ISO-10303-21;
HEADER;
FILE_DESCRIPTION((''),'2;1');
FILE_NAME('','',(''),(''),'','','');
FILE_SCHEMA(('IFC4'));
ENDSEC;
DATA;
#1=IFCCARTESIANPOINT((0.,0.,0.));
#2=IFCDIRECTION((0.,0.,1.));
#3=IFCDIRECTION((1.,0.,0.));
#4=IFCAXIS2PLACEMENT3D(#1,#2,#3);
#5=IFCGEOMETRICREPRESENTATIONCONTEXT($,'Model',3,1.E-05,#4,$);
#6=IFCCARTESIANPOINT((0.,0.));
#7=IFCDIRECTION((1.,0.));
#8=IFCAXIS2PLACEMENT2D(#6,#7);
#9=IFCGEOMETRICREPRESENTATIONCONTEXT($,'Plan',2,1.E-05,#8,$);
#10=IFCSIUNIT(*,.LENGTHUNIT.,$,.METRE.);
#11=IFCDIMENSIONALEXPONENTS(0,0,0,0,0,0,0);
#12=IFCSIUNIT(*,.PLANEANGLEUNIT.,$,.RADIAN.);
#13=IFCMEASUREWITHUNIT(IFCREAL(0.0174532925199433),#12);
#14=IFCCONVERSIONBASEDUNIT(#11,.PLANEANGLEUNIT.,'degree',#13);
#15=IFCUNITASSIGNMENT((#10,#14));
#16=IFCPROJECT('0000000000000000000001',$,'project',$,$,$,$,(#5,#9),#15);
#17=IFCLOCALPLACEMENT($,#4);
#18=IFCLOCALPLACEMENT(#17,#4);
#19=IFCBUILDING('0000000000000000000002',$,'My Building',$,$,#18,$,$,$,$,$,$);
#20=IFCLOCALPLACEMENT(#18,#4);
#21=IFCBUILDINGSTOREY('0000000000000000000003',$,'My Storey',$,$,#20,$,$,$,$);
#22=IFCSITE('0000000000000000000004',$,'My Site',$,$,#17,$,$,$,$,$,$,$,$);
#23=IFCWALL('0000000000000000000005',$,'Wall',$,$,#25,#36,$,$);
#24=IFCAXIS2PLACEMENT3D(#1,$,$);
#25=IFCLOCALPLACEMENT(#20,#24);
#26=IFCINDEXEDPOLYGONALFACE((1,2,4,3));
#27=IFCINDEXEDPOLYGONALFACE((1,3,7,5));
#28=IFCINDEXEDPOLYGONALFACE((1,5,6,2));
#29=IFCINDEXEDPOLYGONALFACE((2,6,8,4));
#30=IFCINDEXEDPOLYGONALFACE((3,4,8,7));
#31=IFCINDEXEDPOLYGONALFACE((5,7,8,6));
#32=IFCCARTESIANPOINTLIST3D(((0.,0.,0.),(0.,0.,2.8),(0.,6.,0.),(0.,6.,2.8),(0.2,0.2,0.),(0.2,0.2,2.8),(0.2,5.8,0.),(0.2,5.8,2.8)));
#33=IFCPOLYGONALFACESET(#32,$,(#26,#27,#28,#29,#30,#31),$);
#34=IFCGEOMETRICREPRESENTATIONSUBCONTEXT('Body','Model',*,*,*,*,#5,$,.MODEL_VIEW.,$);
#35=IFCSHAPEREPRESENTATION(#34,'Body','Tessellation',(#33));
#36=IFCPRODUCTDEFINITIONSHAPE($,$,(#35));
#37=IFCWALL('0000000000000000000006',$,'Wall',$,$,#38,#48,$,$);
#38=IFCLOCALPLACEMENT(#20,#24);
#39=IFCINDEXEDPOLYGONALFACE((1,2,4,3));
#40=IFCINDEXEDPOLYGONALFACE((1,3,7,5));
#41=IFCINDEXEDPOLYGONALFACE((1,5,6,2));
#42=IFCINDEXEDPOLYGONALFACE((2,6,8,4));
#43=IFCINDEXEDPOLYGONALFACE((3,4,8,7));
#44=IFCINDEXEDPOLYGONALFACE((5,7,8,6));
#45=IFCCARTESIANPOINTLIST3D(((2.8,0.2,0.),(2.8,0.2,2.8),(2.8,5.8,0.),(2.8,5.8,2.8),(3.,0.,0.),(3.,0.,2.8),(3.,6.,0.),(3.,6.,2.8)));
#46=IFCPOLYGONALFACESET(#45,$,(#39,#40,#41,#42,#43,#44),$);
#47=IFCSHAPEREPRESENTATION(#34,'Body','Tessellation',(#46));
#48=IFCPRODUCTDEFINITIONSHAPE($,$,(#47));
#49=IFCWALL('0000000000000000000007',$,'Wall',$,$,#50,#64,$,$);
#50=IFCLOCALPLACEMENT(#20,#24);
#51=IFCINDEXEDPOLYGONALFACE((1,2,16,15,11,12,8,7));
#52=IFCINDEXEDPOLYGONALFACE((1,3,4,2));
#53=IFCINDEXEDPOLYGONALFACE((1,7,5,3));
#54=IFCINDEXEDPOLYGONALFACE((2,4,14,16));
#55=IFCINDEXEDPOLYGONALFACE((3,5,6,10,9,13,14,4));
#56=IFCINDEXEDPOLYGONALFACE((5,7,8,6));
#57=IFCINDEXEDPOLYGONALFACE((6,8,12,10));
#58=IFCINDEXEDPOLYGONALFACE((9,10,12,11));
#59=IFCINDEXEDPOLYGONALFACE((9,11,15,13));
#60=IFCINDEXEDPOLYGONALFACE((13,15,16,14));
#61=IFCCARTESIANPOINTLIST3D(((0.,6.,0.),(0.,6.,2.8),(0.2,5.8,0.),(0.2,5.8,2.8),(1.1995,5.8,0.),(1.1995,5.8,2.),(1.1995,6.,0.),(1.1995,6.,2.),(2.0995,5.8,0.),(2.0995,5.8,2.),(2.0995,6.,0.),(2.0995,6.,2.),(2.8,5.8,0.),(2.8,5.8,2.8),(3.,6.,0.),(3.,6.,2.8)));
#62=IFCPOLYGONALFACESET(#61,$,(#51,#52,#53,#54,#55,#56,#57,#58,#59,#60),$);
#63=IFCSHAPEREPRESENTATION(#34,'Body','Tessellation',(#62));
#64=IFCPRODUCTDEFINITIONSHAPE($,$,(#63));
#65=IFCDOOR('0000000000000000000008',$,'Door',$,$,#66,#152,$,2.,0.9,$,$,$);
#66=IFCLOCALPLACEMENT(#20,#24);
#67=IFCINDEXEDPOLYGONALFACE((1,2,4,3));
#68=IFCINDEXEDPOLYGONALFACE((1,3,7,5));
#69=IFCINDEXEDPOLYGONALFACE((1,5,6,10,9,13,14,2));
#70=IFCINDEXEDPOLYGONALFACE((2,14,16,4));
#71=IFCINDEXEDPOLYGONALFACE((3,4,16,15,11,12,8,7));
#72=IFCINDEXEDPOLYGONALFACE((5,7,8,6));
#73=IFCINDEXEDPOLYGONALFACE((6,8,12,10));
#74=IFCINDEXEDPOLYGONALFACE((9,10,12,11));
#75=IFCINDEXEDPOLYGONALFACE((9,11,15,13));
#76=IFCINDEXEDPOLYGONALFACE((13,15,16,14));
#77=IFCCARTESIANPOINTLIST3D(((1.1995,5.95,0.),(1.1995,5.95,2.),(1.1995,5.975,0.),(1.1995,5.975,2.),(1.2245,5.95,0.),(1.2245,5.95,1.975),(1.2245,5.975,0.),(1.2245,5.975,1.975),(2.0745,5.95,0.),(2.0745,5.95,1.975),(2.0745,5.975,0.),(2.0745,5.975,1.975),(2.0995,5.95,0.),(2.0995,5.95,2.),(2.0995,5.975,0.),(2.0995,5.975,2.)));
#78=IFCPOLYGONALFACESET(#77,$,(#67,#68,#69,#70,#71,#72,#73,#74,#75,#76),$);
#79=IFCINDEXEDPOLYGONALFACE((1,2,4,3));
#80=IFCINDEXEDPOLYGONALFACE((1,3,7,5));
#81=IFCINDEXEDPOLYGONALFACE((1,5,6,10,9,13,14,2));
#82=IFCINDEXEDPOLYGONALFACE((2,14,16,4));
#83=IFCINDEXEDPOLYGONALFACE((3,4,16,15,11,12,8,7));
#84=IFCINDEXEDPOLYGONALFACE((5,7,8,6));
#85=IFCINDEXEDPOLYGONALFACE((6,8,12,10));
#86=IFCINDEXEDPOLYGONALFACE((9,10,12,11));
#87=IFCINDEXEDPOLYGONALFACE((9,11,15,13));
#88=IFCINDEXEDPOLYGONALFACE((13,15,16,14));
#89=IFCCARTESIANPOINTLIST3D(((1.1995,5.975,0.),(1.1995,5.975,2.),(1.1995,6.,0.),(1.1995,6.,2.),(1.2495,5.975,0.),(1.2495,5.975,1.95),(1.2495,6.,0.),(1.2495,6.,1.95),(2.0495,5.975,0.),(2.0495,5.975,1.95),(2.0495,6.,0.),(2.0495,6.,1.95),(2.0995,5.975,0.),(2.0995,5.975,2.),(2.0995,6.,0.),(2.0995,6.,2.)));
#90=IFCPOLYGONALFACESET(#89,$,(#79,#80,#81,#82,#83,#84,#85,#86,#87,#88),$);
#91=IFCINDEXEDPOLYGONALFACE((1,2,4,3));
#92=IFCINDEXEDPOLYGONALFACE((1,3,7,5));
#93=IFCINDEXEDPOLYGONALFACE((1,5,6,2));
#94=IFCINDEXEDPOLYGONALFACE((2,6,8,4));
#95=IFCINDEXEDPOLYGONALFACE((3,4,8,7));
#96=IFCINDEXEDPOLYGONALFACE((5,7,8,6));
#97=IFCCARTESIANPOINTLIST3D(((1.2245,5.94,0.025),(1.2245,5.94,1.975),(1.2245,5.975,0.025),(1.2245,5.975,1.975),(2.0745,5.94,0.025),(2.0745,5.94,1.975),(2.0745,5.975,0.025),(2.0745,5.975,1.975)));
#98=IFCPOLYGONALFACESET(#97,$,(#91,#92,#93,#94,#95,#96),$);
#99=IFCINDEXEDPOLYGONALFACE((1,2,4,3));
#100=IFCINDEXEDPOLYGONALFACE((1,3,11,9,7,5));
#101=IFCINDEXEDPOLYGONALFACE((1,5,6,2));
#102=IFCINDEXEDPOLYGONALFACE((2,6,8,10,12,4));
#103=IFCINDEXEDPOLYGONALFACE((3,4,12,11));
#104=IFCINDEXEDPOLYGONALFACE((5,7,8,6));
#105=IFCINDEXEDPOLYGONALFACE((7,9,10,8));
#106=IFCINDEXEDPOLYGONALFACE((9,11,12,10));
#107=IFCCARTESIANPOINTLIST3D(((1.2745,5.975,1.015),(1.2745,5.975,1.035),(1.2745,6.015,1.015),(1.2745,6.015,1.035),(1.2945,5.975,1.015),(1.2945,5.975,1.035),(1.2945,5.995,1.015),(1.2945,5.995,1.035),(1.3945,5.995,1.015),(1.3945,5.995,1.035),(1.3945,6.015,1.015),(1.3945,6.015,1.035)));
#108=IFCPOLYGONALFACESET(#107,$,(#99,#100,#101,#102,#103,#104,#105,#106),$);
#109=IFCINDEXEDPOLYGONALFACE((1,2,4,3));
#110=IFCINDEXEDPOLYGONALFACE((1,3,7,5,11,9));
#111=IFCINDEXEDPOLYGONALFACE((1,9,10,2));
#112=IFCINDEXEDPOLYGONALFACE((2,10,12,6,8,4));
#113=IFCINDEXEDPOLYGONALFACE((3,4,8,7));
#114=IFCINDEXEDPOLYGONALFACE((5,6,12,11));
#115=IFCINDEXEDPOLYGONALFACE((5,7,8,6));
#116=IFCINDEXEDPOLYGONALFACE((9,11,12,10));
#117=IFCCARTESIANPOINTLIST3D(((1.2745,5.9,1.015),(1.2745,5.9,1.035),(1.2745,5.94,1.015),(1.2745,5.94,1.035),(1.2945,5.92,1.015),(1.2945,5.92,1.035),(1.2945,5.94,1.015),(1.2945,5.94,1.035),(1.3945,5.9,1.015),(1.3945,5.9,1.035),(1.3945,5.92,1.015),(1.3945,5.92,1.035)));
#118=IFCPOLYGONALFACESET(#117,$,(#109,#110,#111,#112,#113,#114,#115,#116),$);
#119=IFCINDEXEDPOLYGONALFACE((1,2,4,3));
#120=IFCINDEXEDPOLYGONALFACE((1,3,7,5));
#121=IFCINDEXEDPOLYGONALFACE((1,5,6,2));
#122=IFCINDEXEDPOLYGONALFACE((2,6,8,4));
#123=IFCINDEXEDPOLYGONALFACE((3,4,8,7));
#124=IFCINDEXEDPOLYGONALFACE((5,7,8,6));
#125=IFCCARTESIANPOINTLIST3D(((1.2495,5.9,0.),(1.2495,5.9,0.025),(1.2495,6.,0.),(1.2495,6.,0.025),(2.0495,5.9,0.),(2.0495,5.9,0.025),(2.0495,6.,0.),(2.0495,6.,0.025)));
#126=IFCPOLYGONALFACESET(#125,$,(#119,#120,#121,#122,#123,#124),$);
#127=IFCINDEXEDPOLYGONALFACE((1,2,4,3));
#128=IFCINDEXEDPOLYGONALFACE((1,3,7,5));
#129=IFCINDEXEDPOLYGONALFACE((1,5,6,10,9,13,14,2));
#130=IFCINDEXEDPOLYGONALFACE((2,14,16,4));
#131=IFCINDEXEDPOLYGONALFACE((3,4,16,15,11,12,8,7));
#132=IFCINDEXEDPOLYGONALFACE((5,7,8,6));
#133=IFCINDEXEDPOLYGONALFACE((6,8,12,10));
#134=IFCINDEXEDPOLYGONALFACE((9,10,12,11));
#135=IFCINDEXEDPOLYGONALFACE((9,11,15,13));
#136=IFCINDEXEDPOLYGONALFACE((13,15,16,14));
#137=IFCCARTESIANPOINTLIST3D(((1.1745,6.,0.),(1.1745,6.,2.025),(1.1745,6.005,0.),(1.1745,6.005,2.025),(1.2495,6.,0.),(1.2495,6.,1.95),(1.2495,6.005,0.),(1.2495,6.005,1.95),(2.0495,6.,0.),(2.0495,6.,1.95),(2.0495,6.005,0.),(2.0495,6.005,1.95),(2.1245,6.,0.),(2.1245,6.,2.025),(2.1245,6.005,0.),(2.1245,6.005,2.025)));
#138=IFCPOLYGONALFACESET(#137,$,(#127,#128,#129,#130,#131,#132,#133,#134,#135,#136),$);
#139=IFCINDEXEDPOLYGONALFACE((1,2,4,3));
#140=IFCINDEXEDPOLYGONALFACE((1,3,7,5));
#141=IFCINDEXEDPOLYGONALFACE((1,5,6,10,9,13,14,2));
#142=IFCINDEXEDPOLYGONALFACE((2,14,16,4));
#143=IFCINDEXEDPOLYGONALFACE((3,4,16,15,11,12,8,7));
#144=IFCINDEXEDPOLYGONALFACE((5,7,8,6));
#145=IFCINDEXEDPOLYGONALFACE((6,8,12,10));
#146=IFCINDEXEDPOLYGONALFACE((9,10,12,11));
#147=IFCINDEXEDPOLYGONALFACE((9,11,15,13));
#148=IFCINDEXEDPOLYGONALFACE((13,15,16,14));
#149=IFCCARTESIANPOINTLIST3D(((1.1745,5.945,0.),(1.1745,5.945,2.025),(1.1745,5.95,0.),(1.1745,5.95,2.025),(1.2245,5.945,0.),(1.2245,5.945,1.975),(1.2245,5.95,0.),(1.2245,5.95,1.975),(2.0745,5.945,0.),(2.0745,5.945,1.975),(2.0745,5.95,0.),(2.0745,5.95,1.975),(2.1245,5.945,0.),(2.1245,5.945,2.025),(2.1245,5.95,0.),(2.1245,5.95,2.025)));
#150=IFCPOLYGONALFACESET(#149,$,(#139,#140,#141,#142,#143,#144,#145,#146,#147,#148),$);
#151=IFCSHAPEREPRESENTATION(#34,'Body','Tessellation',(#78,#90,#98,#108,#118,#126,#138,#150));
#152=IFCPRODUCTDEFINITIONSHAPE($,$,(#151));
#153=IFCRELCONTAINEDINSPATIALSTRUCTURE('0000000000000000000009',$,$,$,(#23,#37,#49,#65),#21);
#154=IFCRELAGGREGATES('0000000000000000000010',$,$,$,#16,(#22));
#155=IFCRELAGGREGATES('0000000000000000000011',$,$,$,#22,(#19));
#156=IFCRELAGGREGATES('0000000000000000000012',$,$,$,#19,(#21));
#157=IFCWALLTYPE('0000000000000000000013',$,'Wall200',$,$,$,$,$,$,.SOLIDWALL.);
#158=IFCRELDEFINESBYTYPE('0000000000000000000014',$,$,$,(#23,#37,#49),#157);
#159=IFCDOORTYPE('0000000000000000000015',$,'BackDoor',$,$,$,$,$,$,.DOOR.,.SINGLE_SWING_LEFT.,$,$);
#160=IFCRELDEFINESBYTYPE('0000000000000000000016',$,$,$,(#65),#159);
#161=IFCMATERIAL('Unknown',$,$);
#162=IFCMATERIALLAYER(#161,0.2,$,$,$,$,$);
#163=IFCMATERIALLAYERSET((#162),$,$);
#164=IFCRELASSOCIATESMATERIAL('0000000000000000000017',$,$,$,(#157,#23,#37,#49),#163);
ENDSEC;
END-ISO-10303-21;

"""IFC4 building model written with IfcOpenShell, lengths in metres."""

from ifc_helpers import new_model, entity, si_unit, converted_unit, frame, origin_with_axes, origin_2d_with_axis, place, context, subcontext, project, spatial, line, indexed_curve, outline, extrude, clip, halfspace, shape, source, transform, mapped, material, layer, layer_set, layer_usage, type_object, type_shapes, element, fill, save


model = new_model("IFC4")

# Units and contexts
model_context = context("Model", 3, precision=1e-05, world=origin_with_axes())
plan_context = context("Plan", 2, precision=1e-05, world=origin_2d_with_axis())
body_context_1 = subcontext(model_context, "Body", "Model", "MODEL_VIEW")
body_context_2 = subcontext(plan_context, "Body", "Plan", "PLAN_VIEW")
ifc_project = project(units=[si_unit("LENGTHUNIT", "METRE"), converted_unit("PLANEANGLEUNIT", "degree", entity("IfcReal", 0.0174532925199433), si_unit("PLANEANGLEUNIT", "RADIAN"), dimensions=[0, 0, 0, 0, 0, 0, 0])], contexts=[model_context, plan_context])

# Site, building, storey
site_placement = place(None, origin_with_axes())
site = spatial("IfcSite", under=ifc_project, at=site_placement, Name="My Site")
building_placement = place(site_placement, origin_with_axes())
building = spatial("IfcBuilding", under=site, at=building_placement, Name="My Building")
storey_placement = place(building_placement, origin_with_axes())
storey = spatial("IfcBuildingStorey", under=building, at=storey_placement, Name="My Storey")

# Wall
ifc_material = material(Name="Unknown")
ifc_layer = layer(ifc_material, 0.2)
ifc_layer_set = layer_set([ifc_layer])
ifc_layer_usage_1 = layer_usage(ifc_layer_set, "AXIS2", "POSITIVE", 0.0)
wall_type = type_object("IfcWallType", Name="Wall200", PredefinedType="SOLIDWALL", material=ifc_layer_set)
wall_1_placement = place(storey_placement, frame((0.0, 6.0, 0.0), z_axis=(0.0, 0.0, 1.0), x_axis=(0.0, -1.0, 0.0)))
element("IfcWall", 1, at=wall_1_placement, inside=storey, type_object=wall_type, material=ifc_layer_usage_1, Name="Wall", context=body_context_1, shape_type="Clipping", body=[
    clip(clip(extrude(outline(indexed_curve([(0.0, 0.0), (0.0, 0.2), (6.0, 0.2), (6.0, 0.0), (0.0, 0.0)], self_intersect=False)), origin_with_axes(), (0.0, 0.0, 1.0), 2.8), halfspace(frame((0.0, 0.0, 0.0), z_axis=(-0.707107, 0.707106, 0.0), x_axis=(0.707106, 0.707107, 0.0)), False)), halfspace(frame((6.0, 0.0, 0.0), z_axis=(0.707107, 0.707107, 0.0), x_axis=(0.707107, -0.707107, 0.0)), False)),
])

# Wall
ifc_layer_usage_2 = layer_usage(ifc_layer_set, "AXIS2", "POSITIVE", 0.0)
wall_2_placement = place(storey_placement, frame((3.0, 0.0, 0.0), z_axis=(0.0, 0.0, 1.0), x_axis=(0.000001, 1.0, 0.0)))
element("IfcWall", 2, at=wall_2_placement, inside=storey, type_object=wall_type, material=ifc_layer_usage_2, Name="Wall", context=body_context_1, shape_type="Clipping", body=[
    clip(clip(extrude(outline(indexed_curve([(0.0, 0.0), (0.0, 0.2), (6.0, 0.2), (6.0, 0.0), (0.0, 0.0)], self_intersect=False)), origin_with_axes(), (0.0, 0.0, 1.0), 2.8), halfspace(frame((6.0, 0.0, 0.0), z_axis=(0.707107, 0.707106, 0.0), x_axis=(0.707106, -0.707107, 0.0)), False)), halfspace(frame((0.0, 0.0, 0.0), z_axis=(-0.707106, 0.707107, 0.0), x_axis=(0.707107, 0.707106, 0.0)), False)),
])

# Wall, opening, door
ifc_layer_usage_3 = layer_usage(ifc_layer_set, "AXIS2", "POSITIVE", 0.0)
wall_3_placement = place(storey_placement, frame((3.0, 6.0, 0.0), z_axis=(0.0, 0.0, 1.0), x_axis=(-1.0, 0.000001, 0.0)))
wall_3 = element("IfcWall", 3, at=wall_3_placement, inside=storey, type_object=wall_type, material=ifc_layer_usage_3, Name="Wall", context=body_context_1, shape_type="Clipping", body=[
    clip(clip(extrude(outline(indexed_curve([(0.0, 0.0), (0.0, 0.2), (3.0, 0.2), (3.0, 0.0), (0.0, 0.0)], self_intersect=False)), origin_with_axes(), (0.0, 0.0, 1.0), 2.8), halfspace(frame((0.0, 0.0, 0.0), z_axis=(-0.707105, 0.707108, 0.0), x_axis=(0.707108, 0.707105, 0.0)), False)), halfspace(frame((3.0, 0.0, 0.0), z_axis=(0.707106, 0.707107, 0.0), x_axis=(0.707107, -0.707106, 0.0)), False)),
])
shared_shape_1 = source(origin_with_axes(), body_context_1, "Body", "SweptSolid", [
    extrude(outline(indexed_curve([(0.0, 0.0), (0.9, 0.0), (0.9, 2.0), (0.0, 2.0)], segments=[line(1, 2, 3, 4, 1)])), frame((0.0, -0.6, 0.0), z_axis=(0.0, -1.0, 0.0), x_axis=(1.0, 0.0, 0.0)), (0.0, 0.0, -1.0), 1.2),
])
opening_1_placement = place(wall_3_placement, frame((0.9006, 0.0, 0.0), z_axis=(0.0, 0.0, 1.0), x_axis=(1.0, 0.0, 0.0)))
opening_1 = element("IfcOpeningElement", 4, at=opening_1_placement, cuts=wall_3, PredefinedType="OPENING", context=body_context_1, shape_type="MappedRepresentation", body=[
    mapped(shared_shape_1, transform((0.0, 0.0, 0.0), x_axis=(1.0, 0.0, 0.0), y_axis=(0.0, 1.0, 0.0), z_axis=(0.0, 0.0, 1.0), scale=1.0)),
])
door_type_1 = type_object("IfcDoorType", Name="BackDoor", OperationType="SINGLE_SWING_LEFT", PredefinedType="DOOR")
shared_shape_2 = source(origin_with_axes(), body_context_1, "Body", "SweptSolid", [
    extrude(outline(indexed_curve([(0.0, 0.0), (0.0, 2.0), (0.9, 2.0), (0.9, 0.0), (0.875, 0.0), (0.875, 1.975), (0.025, 1.975), (0.025, 0.0)], segments=[line(1, 2, 3, 4, 5, 6, 7, 8, 1)])), frame((0.0, 0.025, 0.0), z_axis=(0.0, -1.0, 0.0), x_axis=(1.0, 0.0, 0.0)), (0.0, 0.0, -1.0), 0.025),
    extrude(outline(indexed_curve([(0.0, 0.0), (0.0, 2.0), (0.9, 2.0), (0.9, 0.0), (0.85, 0.0), (0.85, 1.95), (0.05, 1.95), (0.05, 0.0)], segments=[line(1, 2, 3, 4, 5, 6, 7, 8, 1)])), frame((0.0, 0.0, 0.0), z_axis=(0.0, -1.0, 0.0), x_axis=(1.0, 0.0, 0.0)), (0.0, 0.0, -1.0), 0.025),
    extrude(outline(indexed_curve([(0.0, 0.0), (0.85, 0.0), (0.85, 0.035), (0.0, 0.035)], segments=[line(1, 2, 3, 4, 1)])), frame((0.025, 0.025, 0.025), z_axis=(0.0, 0.0, 1.0), x_axis=(1.0, 0.0, 0.0)), (0.0, 0.0, 1.0), 1.95),
    extrude(outline(indexed_curve([(0.0, 0.0), (0.0, -0.04), (-0.12, -0.04), (-0.12, -0.02), (-0.02, -0.02), (-0.02, 0.0)], segments=[line(1, 2, 3, 4, 5, 6, 1)])), frame((0.825, 0.025, 1.015), z_axis=(0.0, 0.0, 1.0), x_axis=(1.0, 0.0, 0.0)), (0.0, 0.0, 1.0), 0.02),
    extrude(outline(indexed_curve([(0.0, 0.0), (0.0, 0.04), (-0.12, 0.04), (-0.12, 0.02), (-0.02, 0.02), (-0.02, 0.0)], segments=[line(1, 2, 3, 4, 5, 6, 1)])), frame((0.825, 0.06, 1.015), z_axis=(0.0, 0.0, 1.0), x_axis=(1.0, 0.0, 0.0)), (0.0, 0.0, 1.0), 0.02),
    extrude(outline(indexed_curve([(0.0, 0.0), (0.8, 0.0), (0.8, 0.1), (0.0, 0.1)], segments=[line(1, 2, 3, 4, 1)])), frame((0.05, 0.0, 0.0), z_axis=(0.0, 0.0, 1.0), x_axis=(1.0, 0.0, 0.0)), (0.0, 0.0, 1.0), 0.025),
    extrude(outline(indexed_curve([(0.0, 0.0), (0.0, 2.025), (0.95, 2.025), (0.95, 0.0), (0.875, 0.0), (0.875, 1.95), (0.075, 1.95), (0.075, 0.0)], segments=[line(1, 2, 3, 4, 5, 6, 7, 8, 1)])), frame((-0.025, -0.005, 0.0), z_axis=(0.0, -1.0, 0.0), x_axis=(1.0, 0.0, 0.0)), (0.0, 0.0, -1.0), 0.005),
    extrude(outline(indexed_curve([(0.0, 0.0), (0.0, 2.025), (0.95, 2.025), (0.95, 0.0), (0.9, 0.0), (0.9, 1.975), (0.05, 1.975), (0.05, 0.0)], segments=[line(1, 2, 3, 4, 5, 6, 7, 8, 1)])), frame((-0.025, 0.05, 0.0), z_axis=(0.0, -1.0, 0.0), x_axis=(1.0, 0.0, 0.0)), (0.0, 0.0, -1.0), 0.005),
])
shared_shape_3 = source(origin_with_axes(), body_context_2, "Body", "Curve2D", [
    entity("IfcIndexedPolyCurve", entity("IfcCartesianPointList2D", [[0.0, 0.0], [0.0, 0.05], [0.025, 0.05], [0.025, 0.025], [0.05, 0.025], [0.05, 0.0]]), [entity("IfcLineIndex", [1, 2, 3, 4, 5, 6, 1])]),
    entity("IfcIndexedPolyCurve", entity("IfcCartesianPointList2D", [[0.9, 0.0], [0.9, 0.05], [0.875, 0.05], [0.875, 0.025], [0.85, 0.025], [0.85, 0.0]]), [entity("IfcLineIndex", [1, 2, 3, 4, 5, 6, 1])]),
    entity("IfcTrimmedCurve", entity("IfcEllipse", entity("IfcAxis2Placement2D", entity("IfcCartesianPoint", [0.06, 0.05]), entity("IfcDirection", [1.0, 0.0])), 0.815, 0.85), [entity("IfcCartesianPoint", [0.875, 0.05])], [entity("IfcCartesianPoint", [0.06, 0.9])], True, "CARTESIAN"),
    entity("IfcIndexedPolyCurve", entity("IfcCartesianPointList2D", [[0.025, 0.05], [0.06, 0.05], [0.06, 0.9], [0.025, 0.9]]), [entity("IfcLineIndex", [1, 2, 3, 4, 1])]),
])
type_shapes(door_type_1, [shared_shape_2, shared_shape_3])
door_1_placement = place(opening_1_placement, frame((0.0, 0.0, 0.0), z_axis=(0.0, 0.0, 1.0), x_axis=(1.0, 0.0, 0.0)))
door_1 = element("IfcDoor", 5, at=door_1_placement, inside=storey, type_object=door_type_1, Name="Door", OverallHeight=2.0, OverallWidth=0.9, shapes=[
    shape(body_context_1, "Body", "MappedRepresentation", [mapped(shared_shape_2, transform((0.0, 0.0, 0.0), x_axis=(1.0, 0.0, 0.0), y_axis=(0.0, 1.0, 0.0), z_axis=(0.0, 0.0, 1.0), scale=1.0))]),
    shape(body_context_2, "Body", "MappedRepresentation", [mapped(shared_shape_3, transform((0.0, 0.0, 0.0), x_axis=(1.0, 0.0, 0.0), y_axis=(0.0, 1.0, 0.0), z_axis=(0.0, 0.0, 1.0), scale=1.0))]),
])
fill(opening_1, door_1)

save(model, "model.ifc")
